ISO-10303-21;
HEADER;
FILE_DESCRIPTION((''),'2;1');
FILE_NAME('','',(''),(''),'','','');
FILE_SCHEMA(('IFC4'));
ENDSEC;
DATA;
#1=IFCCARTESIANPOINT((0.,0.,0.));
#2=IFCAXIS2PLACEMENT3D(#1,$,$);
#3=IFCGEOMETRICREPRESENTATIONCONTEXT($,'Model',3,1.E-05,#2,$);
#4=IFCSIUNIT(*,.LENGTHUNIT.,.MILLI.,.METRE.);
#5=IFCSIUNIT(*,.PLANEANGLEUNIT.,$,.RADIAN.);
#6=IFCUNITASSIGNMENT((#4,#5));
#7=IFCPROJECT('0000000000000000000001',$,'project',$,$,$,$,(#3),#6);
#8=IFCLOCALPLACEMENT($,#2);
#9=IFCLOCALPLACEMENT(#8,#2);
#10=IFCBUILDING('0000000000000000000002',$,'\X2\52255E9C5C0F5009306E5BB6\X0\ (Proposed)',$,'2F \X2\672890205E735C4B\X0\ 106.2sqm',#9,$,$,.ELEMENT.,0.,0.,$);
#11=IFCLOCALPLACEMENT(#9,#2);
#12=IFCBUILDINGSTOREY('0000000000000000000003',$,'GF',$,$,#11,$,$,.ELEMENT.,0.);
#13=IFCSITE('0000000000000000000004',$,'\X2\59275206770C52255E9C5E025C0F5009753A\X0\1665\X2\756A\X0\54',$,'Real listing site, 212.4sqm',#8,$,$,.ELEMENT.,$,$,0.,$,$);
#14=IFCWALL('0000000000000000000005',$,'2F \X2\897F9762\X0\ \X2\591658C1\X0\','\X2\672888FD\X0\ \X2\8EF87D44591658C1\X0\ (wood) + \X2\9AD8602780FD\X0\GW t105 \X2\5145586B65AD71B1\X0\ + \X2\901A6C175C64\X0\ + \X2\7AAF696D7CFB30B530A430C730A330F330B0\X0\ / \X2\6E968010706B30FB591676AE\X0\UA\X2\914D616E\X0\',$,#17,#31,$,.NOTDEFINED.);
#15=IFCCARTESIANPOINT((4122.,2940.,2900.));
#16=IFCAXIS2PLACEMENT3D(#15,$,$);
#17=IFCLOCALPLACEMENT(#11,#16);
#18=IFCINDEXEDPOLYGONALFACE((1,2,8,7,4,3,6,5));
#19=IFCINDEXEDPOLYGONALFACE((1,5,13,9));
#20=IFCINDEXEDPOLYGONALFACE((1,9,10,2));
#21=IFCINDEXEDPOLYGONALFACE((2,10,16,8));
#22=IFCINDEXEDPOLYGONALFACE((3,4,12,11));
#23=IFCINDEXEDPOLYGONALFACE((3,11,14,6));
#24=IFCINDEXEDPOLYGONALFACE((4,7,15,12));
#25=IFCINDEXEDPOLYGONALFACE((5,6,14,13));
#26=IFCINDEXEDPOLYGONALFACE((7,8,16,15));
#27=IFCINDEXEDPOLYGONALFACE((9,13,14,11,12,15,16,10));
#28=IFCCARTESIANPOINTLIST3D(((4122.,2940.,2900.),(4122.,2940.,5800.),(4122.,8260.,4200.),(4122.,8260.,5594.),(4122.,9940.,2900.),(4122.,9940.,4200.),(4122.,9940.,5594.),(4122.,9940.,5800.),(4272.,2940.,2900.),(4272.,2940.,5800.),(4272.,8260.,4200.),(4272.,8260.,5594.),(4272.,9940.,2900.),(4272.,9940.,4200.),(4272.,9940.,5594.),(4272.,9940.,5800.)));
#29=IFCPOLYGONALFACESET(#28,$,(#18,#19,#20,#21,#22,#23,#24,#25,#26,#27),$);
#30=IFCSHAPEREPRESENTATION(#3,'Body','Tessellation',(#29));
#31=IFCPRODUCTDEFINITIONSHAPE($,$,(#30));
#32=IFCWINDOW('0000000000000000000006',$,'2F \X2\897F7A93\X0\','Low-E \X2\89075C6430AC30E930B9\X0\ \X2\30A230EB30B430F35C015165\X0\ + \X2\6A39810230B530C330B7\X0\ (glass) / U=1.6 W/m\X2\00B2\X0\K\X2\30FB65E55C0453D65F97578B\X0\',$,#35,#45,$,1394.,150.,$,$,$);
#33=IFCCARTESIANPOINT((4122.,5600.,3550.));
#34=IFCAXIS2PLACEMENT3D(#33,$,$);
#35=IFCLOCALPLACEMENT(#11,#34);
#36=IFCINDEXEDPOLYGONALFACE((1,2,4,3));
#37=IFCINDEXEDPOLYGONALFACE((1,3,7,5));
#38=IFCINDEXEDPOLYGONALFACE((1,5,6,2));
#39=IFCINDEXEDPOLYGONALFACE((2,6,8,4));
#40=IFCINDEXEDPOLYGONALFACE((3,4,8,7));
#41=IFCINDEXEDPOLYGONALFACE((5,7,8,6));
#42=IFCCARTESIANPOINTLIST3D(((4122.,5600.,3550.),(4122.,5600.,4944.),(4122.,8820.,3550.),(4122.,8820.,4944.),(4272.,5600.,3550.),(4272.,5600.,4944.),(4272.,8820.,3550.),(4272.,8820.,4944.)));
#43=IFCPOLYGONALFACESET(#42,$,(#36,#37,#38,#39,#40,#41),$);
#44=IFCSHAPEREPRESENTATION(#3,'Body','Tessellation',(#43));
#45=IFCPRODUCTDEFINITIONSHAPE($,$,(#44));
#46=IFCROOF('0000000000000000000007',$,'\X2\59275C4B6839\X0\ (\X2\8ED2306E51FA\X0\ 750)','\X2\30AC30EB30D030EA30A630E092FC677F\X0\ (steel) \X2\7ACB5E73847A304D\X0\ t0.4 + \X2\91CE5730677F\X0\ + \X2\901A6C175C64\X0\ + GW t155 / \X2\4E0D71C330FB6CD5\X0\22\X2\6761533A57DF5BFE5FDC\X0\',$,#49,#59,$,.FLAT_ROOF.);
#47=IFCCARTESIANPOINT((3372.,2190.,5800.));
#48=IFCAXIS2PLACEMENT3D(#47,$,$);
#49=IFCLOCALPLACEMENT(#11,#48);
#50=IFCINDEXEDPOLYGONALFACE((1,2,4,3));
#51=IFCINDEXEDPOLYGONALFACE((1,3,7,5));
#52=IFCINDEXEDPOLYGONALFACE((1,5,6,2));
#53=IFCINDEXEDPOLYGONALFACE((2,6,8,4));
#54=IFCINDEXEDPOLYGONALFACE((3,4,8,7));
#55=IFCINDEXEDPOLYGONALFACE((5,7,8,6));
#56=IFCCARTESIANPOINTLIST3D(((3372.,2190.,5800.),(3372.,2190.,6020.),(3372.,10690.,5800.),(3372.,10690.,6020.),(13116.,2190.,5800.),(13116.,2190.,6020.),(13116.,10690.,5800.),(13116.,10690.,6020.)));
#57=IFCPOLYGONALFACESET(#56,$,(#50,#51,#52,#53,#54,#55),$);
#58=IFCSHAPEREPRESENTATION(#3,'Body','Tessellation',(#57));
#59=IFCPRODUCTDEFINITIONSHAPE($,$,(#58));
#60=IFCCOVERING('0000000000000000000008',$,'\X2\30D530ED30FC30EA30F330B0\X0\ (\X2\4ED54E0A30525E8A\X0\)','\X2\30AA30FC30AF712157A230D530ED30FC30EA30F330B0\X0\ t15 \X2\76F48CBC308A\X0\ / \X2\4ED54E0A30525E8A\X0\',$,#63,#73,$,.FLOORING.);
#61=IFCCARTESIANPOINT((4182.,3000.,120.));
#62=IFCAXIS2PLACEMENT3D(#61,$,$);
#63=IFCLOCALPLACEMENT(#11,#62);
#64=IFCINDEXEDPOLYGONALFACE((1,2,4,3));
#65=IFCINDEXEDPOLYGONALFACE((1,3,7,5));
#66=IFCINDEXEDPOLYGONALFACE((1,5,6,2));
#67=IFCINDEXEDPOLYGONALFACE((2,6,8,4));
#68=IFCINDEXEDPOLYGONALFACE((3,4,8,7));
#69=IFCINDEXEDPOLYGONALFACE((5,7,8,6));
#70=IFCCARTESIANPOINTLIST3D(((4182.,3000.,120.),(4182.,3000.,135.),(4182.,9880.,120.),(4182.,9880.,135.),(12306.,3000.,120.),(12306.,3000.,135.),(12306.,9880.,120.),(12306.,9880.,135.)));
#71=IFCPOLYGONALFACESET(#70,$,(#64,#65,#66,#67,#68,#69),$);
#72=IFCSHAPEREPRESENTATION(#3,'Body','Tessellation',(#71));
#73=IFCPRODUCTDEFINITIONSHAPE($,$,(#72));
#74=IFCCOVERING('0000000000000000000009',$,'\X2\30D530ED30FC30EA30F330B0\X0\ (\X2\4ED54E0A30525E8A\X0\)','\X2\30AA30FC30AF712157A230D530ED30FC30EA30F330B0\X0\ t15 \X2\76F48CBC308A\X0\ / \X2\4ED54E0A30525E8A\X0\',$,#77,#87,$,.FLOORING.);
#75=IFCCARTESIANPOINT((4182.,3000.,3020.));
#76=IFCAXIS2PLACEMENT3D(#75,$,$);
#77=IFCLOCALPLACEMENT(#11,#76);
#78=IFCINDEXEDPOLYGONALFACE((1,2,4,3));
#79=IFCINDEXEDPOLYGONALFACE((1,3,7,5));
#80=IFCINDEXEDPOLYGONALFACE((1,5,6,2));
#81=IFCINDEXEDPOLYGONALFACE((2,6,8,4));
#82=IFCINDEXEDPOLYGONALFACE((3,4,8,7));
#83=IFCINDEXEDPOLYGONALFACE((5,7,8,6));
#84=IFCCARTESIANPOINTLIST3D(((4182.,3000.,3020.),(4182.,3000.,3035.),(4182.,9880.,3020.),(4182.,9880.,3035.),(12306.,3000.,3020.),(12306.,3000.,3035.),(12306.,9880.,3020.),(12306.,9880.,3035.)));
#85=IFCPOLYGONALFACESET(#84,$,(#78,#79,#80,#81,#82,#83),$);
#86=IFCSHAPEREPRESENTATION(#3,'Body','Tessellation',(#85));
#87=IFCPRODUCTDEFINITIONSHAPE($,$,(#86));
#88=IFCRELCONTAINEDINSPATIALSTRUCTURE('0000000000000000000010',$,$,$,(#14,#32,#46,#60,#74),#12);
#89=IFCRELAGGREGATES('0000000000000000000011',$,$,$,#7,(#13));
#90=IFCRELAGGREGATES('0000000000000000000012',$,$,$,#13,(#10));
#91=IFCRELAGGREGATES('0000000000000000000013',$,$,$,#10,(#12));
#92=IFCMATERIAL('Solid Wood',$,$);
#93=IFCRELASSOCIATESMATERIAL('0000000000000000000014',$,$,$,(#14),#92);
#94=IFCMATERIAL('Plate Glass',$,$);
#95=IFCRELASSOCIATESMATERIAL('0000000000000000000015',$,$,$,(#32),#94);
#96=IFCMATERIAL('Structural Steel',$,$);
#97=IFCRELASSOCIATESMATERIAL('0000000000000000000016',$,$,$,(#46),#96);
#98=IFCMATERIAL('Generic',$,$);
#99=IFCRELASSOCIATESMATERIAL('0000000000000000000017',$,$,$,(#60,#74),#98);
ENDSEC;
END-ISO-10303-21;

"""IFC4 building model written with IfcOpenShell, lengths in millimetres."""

from ifc_helpers import new_model, si_unit, frame, frame_2d, origin, place, context, project, spatial, rectangle, extrude, material, element, fill, save


model = new_model("IFC4")

# Units and contexts
model_context = context("Model", 3, precision=1e-05, world=origin())
ifc_project = project(units=[si_unit("LENGTHUNIT", "METRE", prefix="MILLI"), si_unit("PLANEANGLEUNIT", "RADIAN")], contexts=[model_context])

# Site, building, storey
site_placement = place(None, origin())
site = spatial("IfcSite", under=ifc_project, at=site_placement, Name="大分県別府市小倉町1665番54", ObjectType="Real listing site, 212.4sqm", CompositionType="ELEMENT", RefElevation=0.0)
building_placement = place(site_placement, origin())
building = spatial("IfcBuilding", under=site, at=building_placement, Name="別府小倉の家 (Proposed)", ObjectType="2F 木造平屋 106.2sqm", CompositionType="ELEMENT", ElevationOfRefHeight=0.0, ElevationOfTerrain=0.0)
storey_placement = place(building_placement, origin())
storey = spatial("IfcBuildingStorey", under=building, at=storey_placement, Name="GF", CompositionType="ELEMENT", Elevation=0.0)

# Shared definitions
ifc_material_1 = material(Name="Solid Wood")

# Shared definitions
ifc_material_2 = material(Name="Plate Glass")

# Wall, opening, window
wall_1_placement = place(storey_placement, frame((4122.0, 2940.0, 2900.0)))
wall_1 = element("IfcWall", 1, at=wall_1_placement, inside=storey, material=ifc_material_1, Name="2F 西面 外壁", Description="木製 軸組外壁 (wood) + 高性能GW t105 充填断熱 + 通気層 + 窯業系サイディング / 準耐火・外皮UA配慮", PredefinedType="NOTDEFINED", context=model_context, shape_type="SweptSolid", body=[
    extrude(rectangle(XDim=150.0, YDim=7000.0, at=frame_2d((75.0, 3500.0))), frame((4122.0, 2940.0, 2900.0)), (0.0, 0.0, 1.0), 2900.0),
])
opening_1_placement = place(storey_placement, frame((4122.0, 5600.0, 3550.0)))
opening_1 = element("IfcOpeningElement", 2, at=opening_1_placement, cuts=wall_1, PredefinedType="NOTDEFINED", context=model_context, shape_type="SweptSolid", body=[
    extrude(rectangle(XDim=150.0, YDim=3220.0, at=frame_2d((75.0, 1610.0))), frame((4122.0, 5600.0, 3550.0)), (0.0, 0.0, 1.0), 1394.0),
])
window_1_placement = place(storey_placement, frame((4122.0, 5600.0, 3550.0)))
window_1 = element("IfcWindow", 3, at=window_1_placement, inside=storey, material=ifc_material_2, Name="2F 西窓", Description="Low-E 複層ガラス アルゴン封入 + 樹脂サッシ (glass) / U=1.6 W/m²K・日射取得型", OverallHeight=1394.0, OverallWidth=150.0, context=model_context, shape_type="SweptSolid", body=[
    extrude(rectangle(XDim=150.0, YDim=3220.0, at=frame_2d((75.0, 1610.0))), frame((4122.0, 5600.0, 3550.0)), (0.0, 0.0, 1.0), 1394.0),
])
fill(opening_1, window_1)

# Roof
ifc_material_3 = material(Name="Structural Steel")
roof_placement = place(storey_placement, frame((3372.0, 2190.0, 5800.0)))
element("IfcRoof", 4, at=roof_placement, inside=storey, material=ifc_material_3, Name="大屋根 (軒の出 750)", Description="ガルバリウム鋼板 (steel) 立平葺き t0.4 + 野地板 + 通気層 + GW t155 / 不燃・法22条区域対応", PredefinedType="FLAT_ROOF", context=model_context, shape_type="SweptSolid", body=[
    extrude(rectangle(XDim=9744.0, YDim=8500.0, at=frame_2d((4872.0, 4250.0))), frame((3372.0, 2190.0, 5800.0)), (0.0, 0.0, 1.0), 220.0),
])

# Coverings
ifc_material_4 = material(Name="Generic")
covering_1_placement = place(storey_placement, frame((4182.0, 3000.0, 120.0)))
element("IfcCovering", 5, at=covering_1_placement, inside=storey, material=ifc_material_4, Name="フローリング (仕上げ床)", Description="オーク無垢フローリング t15 直貼り / 仕上げ床", PredefinedType="FLOORING", context=model_context, shape_type="SweptSolid", body=[
    extrude(rectangle(XDim=8124.0, YDim=6880.0, at=frame_2d((4062.0, 3440.0))), frame((4182.0, 3000.0, 120.0)), (0.0, 0.0, 1.0), 15.0),
])
covering_2_placement = place(storey_placement, frame((4182.0, 3000.0, 3020.0)))
element("IfcCovering", 6, at=covering_2_placement, inside=storey, material=ifc_material_4, Name="フローリング (仕上げ床)", Description="オーク無垢フローリング t15 直貼り / 仕上げ床", PredefinedType="FLOORING", context=model_context, shape_type="SweptSolid", body=[
    extrude(rectangle(XDim=8124.0, YDim=6880.0, at=frame_2d((4062.0, 3440.0))), frame((4182.0, 3000.0, 3020.0)), (0.0, 0.0, 1.0), 15.0),
])

save(model, "model.ifc")
